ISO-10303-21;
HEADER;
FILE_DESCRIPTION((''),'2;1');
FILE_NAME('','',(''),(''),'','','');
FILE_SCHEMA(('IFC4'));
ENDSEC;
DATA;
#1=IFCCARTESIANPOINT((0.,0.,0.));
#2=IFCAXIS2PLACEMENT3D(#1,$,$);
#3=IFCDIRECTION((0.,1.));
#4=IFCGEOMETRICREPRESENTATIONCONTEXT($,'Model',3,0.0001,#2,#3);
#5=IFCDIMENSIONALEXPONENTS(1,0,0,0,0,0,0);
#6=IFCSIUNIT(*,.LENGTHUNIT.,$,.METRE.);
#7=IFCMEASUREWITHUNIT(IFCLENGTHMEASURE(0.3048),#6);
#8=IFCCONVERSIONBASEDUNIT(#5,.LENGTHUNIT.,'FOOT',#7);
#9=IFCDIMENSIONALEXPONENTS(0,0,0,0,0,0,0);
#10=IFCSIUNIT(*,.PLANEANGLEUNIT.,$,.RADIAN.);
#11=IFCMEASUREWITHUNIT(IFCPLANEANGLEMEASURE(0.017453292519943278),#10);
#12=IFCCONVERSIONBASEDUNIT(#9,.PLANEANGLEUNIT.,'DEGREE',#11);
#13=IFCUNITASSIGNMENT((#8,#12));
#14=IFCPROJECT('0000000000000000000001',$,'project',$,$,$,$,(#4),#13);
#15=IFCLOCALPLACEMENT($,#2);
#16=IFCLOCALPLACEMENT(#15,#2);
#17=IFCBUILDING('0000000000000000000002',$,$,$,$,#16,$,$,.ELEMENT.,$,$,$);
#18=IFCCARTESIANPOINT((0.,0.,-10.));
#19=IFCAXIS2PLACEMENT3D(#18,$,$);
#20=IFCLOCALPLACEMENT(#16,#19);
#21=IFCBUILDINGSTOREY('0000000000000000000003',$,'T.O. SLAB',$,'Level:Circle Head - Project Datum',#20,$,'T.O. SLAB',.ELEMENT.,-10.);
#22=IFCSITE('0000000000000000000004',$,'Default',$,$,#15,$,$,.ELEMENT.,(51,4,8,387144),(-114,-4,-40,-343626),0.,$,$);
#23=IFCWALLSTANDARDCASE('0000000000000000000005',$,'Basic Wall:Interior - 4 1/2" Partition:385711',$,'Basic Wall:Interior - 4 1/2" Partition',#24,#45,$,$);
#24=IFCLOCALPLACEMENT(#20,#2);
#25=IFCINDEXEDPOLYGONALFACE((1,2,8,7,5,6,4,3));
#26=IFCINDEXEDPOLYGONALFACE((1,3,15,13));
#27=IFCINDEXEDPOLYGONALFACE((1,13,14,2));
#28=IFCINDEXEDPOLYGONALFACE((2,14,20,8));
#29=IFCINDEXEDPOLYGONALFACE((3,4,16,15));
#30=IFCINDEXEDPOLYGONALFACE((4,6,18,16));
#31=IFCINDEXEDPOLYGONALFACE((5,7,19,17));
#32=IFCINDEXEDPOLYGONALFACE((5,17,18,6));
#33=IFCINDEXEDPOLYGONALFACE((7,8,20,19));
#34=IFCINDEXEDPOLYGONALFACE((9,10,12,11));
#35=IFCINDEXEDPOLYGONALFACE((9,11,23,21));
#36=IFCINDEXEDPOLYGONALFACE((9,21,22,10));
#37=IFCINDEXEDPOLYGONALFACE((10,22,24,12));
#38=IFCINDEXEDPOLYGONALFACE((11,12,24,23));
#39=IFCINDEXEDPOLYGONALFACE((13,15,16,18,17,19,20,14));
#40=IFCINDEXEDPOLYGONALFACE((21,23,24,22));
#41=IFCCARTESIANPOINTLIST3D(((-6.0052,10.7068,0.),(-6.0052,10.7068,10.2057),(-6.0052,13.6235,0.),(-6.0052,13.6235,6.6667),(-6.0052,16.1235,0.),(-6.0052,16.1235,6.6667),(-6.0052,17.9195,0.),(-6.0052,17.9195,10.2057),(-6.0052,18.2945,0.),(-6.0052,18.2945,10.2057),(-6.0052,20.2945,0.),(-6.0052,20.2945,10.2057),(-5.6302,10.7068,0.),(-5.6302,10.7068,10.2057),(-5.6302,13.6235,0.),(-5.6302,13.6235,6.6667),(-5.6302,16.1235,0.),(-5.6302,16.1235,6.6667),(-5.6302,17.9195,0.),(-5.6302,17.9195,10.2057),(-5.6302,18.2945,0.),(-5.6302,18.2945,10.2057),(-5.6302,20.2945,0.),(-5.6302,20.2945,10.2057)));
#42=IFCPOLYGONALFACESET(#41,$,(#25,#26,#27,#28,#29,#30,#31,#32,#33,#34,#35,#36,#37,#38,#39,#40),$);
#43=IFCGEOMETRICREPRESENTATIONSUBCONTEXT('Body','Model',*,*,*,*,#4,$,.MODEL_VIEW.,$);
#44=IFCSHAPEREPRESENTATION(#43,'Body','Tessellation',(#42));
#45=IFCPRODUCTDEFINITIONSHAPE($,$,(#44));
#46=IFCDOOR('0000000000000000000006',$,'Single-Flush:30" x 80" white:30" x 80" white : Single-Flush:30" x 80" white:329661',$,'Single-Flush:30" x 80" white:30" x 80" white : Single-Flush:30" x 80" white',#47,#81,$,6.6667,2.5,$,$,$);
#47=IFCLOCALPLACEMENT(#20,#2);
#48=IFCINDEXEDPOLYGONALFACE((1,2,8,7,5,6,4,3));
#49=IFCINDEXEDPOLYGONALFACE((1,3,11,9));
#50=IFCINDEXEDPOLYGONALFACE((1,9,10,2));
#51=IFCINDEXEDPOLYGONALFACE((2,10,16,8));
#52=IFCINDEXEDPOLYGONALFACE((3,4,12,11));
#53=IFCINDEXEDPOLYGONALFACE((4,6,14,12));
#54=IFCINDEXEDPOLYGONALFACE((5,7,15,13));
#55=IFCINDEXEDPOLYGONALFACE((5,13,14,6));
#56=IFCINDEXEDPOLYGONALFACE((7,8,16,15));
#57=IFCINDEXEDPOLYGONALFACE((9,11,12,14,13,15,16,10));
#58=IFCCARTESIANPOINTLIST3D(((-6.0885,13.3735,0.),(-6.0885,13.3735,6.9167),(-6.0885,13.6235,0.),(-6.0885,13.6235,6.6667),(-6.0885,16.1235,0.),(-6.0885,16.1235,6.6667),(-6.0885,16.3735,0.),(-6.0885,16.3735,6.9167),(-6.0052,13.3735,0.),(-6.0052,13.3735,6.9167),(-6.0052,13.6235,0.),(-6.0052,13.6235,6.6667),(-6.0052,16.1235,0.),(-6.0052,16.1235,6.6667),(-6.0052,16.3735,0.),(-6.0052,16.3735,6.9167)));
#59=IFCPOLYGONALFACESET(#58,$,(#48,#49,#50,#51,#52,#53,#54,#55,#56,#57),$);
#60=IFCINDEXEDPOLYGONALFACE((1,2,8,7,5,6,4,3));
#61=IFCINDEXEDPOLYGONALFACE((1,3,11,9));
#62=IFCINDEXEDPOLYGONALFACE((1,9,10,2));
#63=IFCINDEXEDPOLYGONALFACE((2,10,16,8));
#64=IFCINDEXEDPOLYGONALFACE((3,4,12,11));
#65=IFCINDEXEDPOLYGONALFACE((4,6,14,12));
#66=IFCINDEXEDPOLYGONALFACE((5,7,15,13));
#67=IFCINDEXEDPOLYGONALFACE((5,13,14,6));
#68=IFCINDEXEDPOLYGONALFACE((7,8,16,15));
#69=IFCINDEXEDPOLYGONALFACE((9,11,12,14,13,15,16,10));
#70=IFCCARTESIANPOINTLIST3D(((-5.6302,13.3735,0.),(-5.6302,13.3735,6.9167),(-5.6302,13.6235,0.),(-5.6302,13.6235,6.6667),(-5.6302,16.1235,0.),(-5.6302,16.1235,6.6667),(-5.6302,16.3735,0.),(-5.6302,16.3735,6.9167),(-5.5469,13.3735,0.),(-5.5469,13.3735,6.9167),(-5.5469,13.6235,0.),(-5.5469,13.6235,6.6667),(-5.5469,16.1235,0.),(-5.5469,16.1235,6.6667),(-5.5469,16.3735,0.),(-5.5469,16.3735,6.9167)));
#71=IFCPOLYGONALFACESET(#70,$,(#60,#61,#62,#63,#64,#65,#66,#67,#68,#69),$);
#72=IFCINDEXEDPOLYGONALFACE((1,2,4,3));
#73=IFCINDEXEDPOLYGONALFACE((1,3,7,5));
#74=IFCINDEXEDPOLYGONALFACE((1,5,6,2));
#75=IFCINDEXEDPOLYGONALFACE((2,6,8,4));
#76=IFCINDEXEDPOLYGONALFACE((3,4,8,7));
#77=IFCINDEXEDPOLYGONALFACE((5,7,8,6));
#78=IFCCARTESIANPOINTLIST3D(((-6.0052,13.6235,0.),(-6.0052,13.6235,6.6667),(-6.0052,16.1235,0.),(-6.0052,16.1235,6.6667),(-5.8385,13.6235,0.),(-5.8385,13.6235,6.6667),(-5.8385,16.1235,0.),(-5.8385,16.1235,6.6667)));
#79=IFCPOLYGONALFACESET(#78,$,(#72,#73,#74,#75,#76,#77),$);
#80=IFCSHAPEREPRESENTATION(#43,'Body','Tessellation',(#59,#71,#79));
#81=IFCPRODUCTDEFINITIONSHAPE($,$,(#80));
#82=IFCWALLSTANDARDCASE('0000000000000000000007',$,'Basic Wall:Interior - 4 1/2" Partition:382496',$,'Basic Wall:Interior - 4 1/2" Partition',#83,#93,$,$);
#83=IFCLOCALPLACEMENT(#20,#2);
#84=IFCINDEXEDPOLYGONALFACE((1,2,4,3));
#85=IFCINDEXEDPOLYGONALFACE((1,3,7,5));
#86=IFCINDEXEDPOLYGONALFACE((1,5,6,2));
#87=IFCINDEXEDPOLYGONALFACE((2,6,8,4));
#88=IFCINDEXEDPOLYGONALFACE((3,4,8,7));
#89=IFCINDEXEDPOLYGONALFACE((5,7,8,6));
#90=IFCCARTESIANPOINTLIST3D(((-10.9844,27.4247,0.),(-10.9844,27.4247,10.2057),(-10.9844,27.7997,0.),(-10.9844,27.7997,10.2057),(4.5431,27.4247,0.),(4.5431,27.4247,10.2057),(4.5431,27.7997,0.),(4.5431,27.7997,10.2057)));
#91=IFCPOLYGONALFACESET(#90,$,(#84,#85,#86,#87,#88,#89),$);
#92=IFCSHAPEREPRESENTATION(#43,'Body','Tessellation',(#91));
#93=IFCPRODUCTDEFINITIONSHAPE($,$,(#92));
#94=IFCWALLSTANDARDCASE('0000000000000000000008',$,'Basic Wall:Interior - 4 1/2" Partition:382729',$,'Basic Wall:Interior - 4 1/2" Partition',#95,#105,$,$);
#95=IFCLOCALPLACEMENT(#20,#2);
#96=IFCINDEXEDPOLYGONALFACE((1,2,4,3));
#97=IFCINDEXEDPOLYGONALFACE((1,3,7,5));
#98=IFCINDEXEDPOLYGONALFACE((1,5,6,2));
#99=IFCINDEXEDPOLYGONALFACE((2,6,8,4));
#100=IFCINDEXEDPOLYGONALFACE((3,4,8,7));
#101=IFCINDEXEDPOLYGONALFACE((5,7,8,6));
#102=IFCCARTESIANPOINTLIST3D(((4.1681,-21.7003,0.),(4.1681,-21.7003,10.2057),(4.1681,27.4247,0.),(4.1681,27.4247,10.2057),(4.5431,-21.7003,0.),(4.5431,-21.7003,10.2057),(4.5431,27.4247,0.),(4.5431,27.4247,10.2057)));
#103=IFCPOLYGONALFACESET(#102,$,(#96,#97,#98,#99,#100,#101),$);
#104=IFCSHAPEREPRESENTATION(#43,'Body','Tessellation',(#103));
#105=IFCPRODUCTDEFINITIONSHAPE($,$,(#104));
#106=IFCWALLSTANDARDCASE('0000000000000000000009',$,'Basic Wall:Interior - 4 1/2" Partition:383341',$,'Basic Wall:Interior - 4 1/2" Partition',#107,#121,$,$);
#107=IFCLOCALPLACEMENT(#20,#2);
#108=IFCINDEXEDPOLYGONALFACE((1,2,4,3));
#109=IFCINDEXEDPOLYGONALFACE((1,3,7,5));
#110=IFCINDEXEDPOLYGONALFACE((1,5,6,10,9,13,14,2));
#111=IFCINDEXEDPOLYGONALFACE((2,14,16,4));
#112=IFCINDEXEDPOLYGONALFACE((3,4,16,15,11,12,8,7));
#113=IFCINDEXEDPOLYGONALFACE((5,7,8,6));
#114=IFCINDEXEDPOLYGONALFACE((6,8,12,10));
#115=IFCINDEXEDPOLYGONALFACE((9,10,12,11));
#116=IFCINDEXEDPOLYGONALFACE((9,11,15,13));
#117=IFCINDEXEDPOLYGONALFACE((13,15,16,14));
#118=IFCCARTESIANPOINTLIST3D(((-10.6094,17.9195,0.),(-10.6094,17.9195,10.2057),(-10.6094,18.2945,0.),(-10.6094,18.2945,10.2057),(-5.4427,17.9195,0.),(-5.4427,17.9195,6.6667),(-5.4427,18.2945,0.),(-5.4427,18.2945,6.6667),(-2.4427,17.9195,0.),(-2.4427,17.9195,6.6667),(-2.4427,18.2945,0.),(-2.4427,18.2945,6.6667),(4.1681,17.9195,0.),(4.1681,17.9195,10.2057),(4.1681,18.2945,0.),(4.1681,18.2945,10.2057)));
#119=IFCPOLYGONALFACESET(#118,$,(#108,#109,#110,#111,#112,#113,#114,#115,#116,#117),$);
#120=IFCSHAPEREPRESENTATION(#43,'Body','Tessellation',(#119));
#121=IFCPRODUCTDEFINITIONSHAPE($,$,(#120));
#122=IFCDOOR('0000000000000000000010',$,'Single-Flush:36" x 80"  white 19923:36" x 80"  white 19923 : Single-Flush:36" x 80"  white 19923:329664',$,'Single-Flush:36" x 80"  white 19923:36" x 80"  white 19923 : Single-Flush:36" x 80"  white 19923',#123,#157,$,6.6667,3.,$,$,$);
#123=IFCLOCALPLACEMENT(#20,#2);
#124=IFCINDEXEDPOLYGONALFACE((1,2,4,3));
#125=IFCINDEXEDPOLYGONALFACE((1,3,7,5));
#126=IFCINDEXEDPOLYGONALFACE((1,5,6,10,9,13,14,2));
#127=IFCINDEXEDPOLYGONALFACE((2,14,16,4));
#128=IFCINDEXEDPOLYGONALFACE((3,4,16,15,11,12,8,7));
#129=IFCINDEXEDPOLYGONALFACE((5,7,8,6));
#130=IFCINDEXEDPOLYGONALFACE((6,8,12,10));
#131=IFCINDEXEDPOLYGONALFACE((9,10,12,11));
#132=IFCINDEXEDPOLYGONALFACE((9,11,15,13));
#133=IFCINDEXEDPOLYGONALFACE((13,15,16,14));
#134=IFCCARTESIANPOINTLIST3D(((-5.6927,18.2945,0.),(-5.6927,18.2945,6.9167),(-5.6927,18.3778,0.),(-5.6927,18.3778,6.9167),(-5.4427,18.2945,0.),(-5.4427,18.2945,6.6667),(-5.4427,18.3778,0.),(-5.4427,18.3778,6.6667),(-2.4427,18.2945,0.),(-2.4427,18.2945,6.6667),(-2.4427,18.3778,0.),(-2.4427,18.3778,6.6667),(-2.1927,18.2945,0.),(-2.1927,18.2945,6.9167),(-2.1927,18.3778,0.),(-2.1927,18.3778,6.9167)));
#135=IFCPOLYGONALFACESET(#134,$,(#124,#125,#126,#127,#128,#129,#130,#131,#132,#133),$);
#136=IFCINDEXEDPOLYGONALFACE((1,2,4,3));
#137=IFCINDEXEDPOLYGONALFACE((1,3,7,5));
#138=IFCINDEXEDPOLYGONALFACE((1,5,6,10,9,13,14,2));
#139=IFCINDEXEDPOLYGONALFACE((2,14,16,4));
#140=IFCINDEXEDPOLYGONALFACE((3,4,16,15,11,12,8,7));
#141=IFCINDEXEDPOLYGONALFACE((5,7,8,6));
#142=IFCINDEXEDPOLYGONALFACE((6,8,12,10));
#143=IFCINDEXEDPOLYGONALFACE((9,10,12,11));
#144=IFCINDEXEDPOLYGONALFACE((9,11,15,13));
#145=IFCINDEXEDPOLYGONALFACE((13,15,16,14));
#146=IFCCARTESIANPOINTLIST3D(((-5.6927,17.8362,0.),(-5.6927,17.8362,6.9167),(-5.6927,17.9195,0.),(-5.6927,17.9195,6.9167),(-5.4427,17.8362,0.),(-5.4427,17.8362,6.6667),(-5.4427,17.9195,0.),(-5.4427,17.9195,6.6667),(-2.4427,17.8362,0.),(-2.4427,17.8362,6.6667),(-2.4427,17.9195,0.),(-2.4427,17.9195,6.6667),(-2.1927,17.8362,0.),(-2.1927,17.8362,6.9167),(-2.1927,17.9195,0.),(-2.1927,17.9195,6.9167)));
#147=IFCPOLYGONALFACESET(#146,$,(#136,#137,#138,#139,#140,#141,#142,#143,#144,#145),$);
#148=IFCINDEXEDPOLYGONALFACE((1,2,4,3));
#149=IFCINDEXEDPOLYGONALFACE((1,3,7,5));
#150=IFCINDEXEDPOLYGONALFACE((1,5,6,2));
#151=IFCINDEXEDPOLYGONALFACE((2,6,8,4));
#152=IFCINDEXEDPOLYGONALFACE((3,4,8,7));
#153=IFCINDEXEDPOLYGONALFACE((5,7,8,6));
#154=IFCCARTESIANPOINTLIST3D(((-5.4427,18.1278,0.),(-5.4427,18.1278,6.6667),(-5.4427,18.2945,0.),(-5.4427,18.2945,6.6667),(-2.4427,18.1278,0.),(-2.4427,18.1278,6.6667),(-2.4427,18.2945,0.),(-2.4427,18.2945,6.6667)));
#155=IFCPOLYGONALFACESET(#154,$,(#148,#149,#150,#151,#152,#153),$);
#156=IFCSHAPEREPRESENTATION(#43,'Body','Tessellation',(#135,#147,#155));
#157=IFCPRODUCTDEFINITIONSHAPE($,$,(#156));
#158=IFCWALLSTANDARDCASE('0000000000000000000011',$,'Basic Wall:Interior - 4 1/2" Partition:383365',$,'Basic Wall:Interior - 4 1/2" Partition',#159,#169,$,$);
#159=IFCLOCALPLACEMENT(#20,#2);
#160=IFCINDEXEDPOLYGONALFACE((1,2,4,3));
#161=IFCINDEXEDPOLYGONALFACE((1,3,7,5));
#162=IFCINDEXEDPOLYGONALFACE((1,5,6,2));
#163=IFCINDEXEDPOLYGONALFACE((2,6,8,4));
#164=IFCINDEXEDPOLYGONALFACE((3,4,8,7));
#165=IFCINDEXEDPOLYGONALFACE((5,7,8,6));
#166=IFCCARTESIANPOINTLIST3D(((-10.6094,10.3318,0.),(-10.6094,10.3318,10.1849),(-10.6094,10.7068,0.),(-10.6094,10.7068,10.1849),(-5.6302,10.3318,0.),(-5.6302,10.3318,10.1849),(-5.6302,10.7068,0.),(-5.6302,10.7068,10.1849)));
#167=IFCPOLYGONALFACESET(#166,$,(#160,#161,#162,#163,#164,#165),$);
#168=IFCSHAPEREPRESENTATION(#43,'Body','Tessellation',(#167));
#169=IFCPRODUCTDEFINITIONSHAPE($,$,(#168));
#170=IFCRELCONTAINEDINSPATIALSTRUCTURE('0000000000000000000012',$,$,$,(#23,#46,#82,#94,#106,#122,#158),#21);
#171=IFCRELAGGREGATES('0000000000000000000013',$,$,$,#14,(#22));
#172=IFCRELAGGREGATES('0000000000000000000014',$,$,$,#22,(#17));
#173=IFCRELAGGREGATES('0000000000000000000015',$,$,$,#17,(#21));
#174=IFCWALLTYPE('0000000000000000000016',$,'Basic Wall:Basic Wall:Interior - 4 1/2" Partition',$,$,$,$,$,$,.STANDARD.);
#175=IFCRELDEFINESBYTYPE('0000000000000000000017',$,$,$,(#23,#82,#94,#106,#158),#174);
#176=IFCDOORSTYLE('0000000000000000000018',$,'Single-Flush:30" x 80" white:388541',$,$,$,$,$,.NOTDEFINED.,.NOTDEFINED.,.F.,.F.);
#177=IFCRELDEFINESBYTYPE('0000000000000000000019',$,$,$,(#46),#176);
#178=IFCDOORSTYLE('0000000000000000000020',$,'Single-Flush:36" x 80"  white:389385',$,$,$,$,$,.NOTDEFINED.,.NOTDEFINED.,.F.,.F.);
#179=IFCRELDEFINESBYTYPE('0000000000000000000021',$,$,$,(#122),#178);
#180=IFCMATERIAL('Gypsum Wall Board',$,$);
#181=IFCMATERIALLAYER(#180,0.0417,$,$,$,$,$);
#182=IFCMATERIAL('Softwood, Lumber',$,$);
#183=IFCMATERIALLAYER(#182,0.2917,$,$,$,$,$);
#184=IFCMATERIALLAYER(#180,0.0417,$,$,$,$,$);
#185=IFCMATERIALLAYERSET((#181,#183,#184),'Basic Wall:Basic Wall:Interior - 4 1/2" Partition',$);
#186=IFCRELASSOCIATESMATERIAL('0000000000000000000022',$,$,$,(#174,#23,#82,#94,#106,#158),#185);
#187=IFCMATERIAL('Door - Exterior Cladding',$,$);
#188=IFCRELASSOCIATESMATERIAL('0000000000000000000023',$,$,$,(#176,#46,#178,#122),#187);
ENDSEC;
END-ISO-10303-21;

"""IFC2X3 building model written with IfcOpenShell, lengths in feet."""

from ifc_helpers import new_model, entity, si_unit, converted_unit, direction, frame, frame_2d, origin, place, context, subcontext, project, spatial, polyline, rectangle, outline, extrude, source, transform, mapped, material, layer, layer_set, layer_usage, type_object, type_shapes, element, fill, save


model = new_model("IFC2X3")

# Units and contexts
model_context = context("Model", 3, precision=0.0001, world=origin(), true_north=direction((0.0, 1.0)))
body_context = subcontext(model_context, "Body", "Model", "MODEL_VIEW")
ifc_project = project(units=[converted_unit("LENGTHUNIT", "FOOT", entity("IfcLengthMeasure", 0.3048), si_unit("LENGTHUNIT", "METRE"), dimensions=[1, 0, 0, 0, 0, 0, 0]), converted_unit("PLANEANGLEUNIT", "DEGREE", entity("IfcPlaneAngleMeasure", 0.017453292519943278), si_unit("PLANEANGLEUNIT", "RADIAN"), dimensions=[0, 0, 0, 0, 0, 0, 0])], contexts=[model_context])

# Site, building, storey
site_placement = place(None, origin())
site = spatial("IfcSite", under=ifc_project, at=site_placement, Name="Default", CompositionType="ELEMENT", RefLatitude=(51, 4, 8, 387144), RefLongitude=(-114, -4, -40, -343626), RefElevation=0.0)
building_placement = place(site_placement, origin())
building = spatial("IfcBuilding", under=site, at=building_placement, CompositionType="ELEMENT")
storey_placement = place(building_placement, frame((0.0, 0.0, -10.0)))
storey = spatial("IfcBuildingStorey", under=building, at=storey_placement, Name="T.O. SLAB", ObjectType="Level:Circle Head - Project Datum", LongName="T.O. SLAB", CompositionType="ELEMENT", Elevation=-10.0)

# Wall, openings, door
ifc_material_1 = material(Name="Gypsum Wall Board")
ifc_layer_1 = layer(ifc_material_1, 0.0417)
ifc_material_2 = material(Name="Softwood, Lumber")
ifc_layer_2 = layer(ifc_material_2, 0.2917)
ifc_layer_3 = layer(ifc_material_1, 0.0417)
ifc_layer_set_1 = layer_set([ifc_layer_1, ifc_layer_2, ifc_layer_3], Name="Basic Wall:Basic Wall:Interior - 4 1/2\" Partition")
ifc_layer_usage_1 = layer_usage(ifc_layer_set_1, "AXIS2", "NEGATIVE", 0.1875)
wall_type_1 = type_object("IfcWallType", Name="Basic Wall:Basic Wall:Interior - 4 1/2\" Partition", PredefinedType="STANDARD", material=ifc_layer_set_1)
wall_1_placement = place(storey_placement, frame((-5.8177, 20.2945, 0.0), z_axis=(0.0, 0.0, 1.0), x_axis=(0.0, -1.0, 0.0)))
wall_1 = element("IfcWallStandardCase", 1, at=wall_1_placement, inside=storey, type_object=wall_type_1, material=ifc_layer_usage_1, Name="Basic Wall:Interior - 4 1/2\" Partition:385711", ObjectType="Basic Wall:Interior - 4 1/2\" Partition", context=body_context, shape_type="SweptSolid", body=[
    extrude(rectangle(XDim=9.5877, YDim=0.375, at=frame_2d((4.7938, 0.0), x_axis=(-1.0, 0.0))), origin(), (0.0, 0.0, 1.0), 10.2057),
])
opening_1_placement = place(wall_1_placement, origin())
element("IfcOpeningElement", 2, at=opening_1_placement, cuts=wall_1, ObjectType="Opening", context=body_context, shape_type="SweptSolid", body=[
    extrude(rectangle(XDim=10.2057, YDim=0.375, at=frame_2d((0.0, 0.0), x_axis=(0.0, 1.0))), frame((2.1875, -0.1875, 5.1029), z_axis=(0.0, 1.0, 0.0), x_axis=(1.0, 0.0, 0.0)), (0.0, 0.0, 1.0), 0.375),
])
opening_2_placement = place(wall_1_placement, frame((20.2945, 5.8177, 0.0), z_axis=(0.0, 0.0, 1.0), x_axis=(0.0, 1.0, 0.0)))
opening_2 = element("IfcOpeningElement", 3, at=opening_2_placement, cuts=wall_1, ObjectType="Opening", context=body_context, shape_type="SweptSolid", body=[
    extrude(rectangle(XDim=6.6667, YDim=2.5, at=frame_2d((0.0, 0.0), x_axis=(0.0, 1.0))), frame((-6.009, 14.8735, 3.3333), z_axis=(1.0, 0.0, 0.0), x_axis=(0.0, -1.0, 0.0)), (0.0, 0.0, 1.0), 0.3825),
])
ifc_material_3 = material(Name="Door - Exterior Cladding")
door_style_1 = type_object("IfcDoorStyle", Name="Single-Flush:30\" x 80\" white:388541", ConstructionType="NOTDEFINED", OperationType="NOTDEFINED", ParameterTakesPrecedence=False, Sizeable=False, material=ifc_material_3)
shared_shape_1 = source(origin(), body_context, "Body", "SweptSolid", [
    extrude(outline(polyline([(-3.5208, -1.5), (3.3958, -1.5), (3.3958, -1.25), (-3.2708, -1.25), (-3.2708, 1.25), (3.3958, 1.25), (3.3958, 1.5), (-3.5208, 1.5), (-3.5208, -1.5)])), frame((1.25, 0.3788, 3.3958), z_axis=(0.0, 1.0, 0.0), x_axis=(0.0, 0.0, -1.0)), (0.0, 0.0, 1.0), 0.0833),
    extrude(outline(polyline([(-1.5, -3.3958), (-1.25, -3.3958), (-1.25, 3.2708), (1.25, 3.2708), (1.25, -3.3958), (1.5, -3.3958), (1.5, 3.5208), (-1.5, 3.5208), (-1.5, -3.3958)])), frame((1.25, -0.0796, 3.3958), z_axis=(0.0, 1.0, 0.0), x_axis=(-1.0, 0.0, 0.0)), (0.0, 0.0, 1.0), 0.0833),
    extrude(rectangle(XDim=2.5, YDim=0.1667, at=frame_2d((0.0, 0.0), x_axis=(1.0, 0.0))), frame((1.25, 0.2954, 0.0), z_axis=(0.0, 0.0, 1.0), x_axis=(-1.0, 0.0, 0.0)), (0.0, 0.0, 1.0), 6.6667),
])
type_shapes(door_style_1, [shared_shape_1])
door_1_placement = place(opening_2_placement, frame((-5.6265, 13.6235, 0.0), z_axis=(0.0, 0.0, 1.0), x_axis=(0.0, 1.0, 0.0)))
door_1 = element("IfcDoor", 4, at=door_1_placement, inside=storey, type_object=door_style_1, material=ifc_material_3, Name="Single-Flush:30\" x 80\" white:30\" x 80\" white : Single-Flush:30\" x 80\" white:329661", ObjectType="Single-Flush:30\" x 80\" white:30\" x 80\" white : Single-Flush:30\" x 80\" white", OverallHeight=6.6667, OverallWidth=2.5, context=body_context, shape_type="MappedRepresentation", body=[
    mapped(shared_shape_1, transform((0.0, 0.0, 0.0), scale=1.0)),
])
fill(opening_2, door_1)

# Walls
ifc_layer_usage_2 = layer_usage(ifc_layer_set_1, "AXIS2", "NEGATIVE", 0.1875)
wall_2_placement = place(storey_placement, frame((-10.9844, 27.6122, 0.0)))
element("IfcWallStandardCase", 5, at=wall_2_placement, inside=storey, type_object=wall_type_1, material=ifc_layer_usage_2, Name="Basic Wall:Interior - 4 1/2\" Partition:382496", ObjectType="Basic Wall:Interior - 4 1/2\" Partition", context=body_context, shape_type="SweptSolid", body=[
    extrude(rectangle(XDim=15.5275, YDim=0.375, at=frame_2d((7.7637, 0.0), x_axis=(-1.0, 0.0))), origin(), (0.0, 0.0, 1.0), 10.2057),
])
ifc_layer_usage_3 = layer_usage(ifc_layer_set_1, "AXIS2", "NEGATIVE", 0.1875)
wall_3_placement = place(storey_placement, frame((4.3556, 27.4247, 0.0), z_axis=(0.0, 0.0, 1.0), x_axis=(0.0, -1.0, 0.0)))
element("IfcWallStandardCase", 6, at=wall_3_placement, inside=storey, type_object=wall_type_1, material=ifc_layer_usage_3, Name="Basic Wall:Interior - 4 1/2\" Partition:382729", ObjectType="Basic Wall:Interior - 4 1/2\" Partition", context=body_context, shape_type="SweptSolid", body=[
    extrude(rectangle(XDim=49.125, YDim=0.375, at=frame_2d((24.5625, 0.0), x_axis=(-1.0, 0.0))), origin(), (0.0, 0.0, 1.0), 10.2057),
])

# Wall, opening, door
ifc_layer_usage_4 = layer_usage(ifc_layer_set_1, "AXIS2", "NEGATIVE", 0.1875)
wall_4_placement = place(storey_placement, frame((-10.6094, 18.107, 0.0)))
wall_4 = element("IfcWallStandardCase", 7, at=wall_4_placement, inside=storey, type_object=wall_type_1, material=ifc_layer_usage_4, Name="Basic Wall:Interior - 4 1/2\" Partition:383341", ObjectType="Basic Wall:Interior - 4 1/2\" Partition", context=body_context, shape_type="SweptSolid", body=[
    extrude(rectangle(XDim=0.375, YDim=14.7775, at=frame_2d((7.3887, 0.0), x_axis=(0.0, 1.0))), origin(), (0.0, 0.0, 1.0), 10.2057),
])
opening_3_placement = place(wall_4_placement, frame((10.6094, -18.107, 0.0)))
opening_3 = element("IfcOpeningElement", 8, at=opening_3_placement, cuts=wall_4, ObjectType="Opening", context=body_context, shape_type="SweptSolid", body=[
    extrude(rectangle(XDim=6.6667, YDim=3.0, at=frame_2d((0.0, 0.0), x_axis=(1.0, 0.0))), frame((-3.9427, 17.9158, 3.3333), z_axis=(0.0, 1.0, 0.0), x_axis=(0.0, 0.0, 1.0)), (0.0, 0.0, 1.0), 0.3825),
])
door_style_2 = type_object("IfcDoorStyle", Name="Single-Flush:36\" x 80\"  white:389385", ConstructionType="NOTDEFINED", OperationType="NOTDEFINED", ParameterTakesPrecedence=False, Sizeable=False, material=ifc_material_3)
shared_shape_2 = source(origin(), body_context, "Body", "SweptSolid", [
    extrude(outline(polyline([(-1.75, -3.5208), (1.75, -3.5208), (1.75, 3.3958), (1.5, 3.3958), (1.5, -3.2708), (-1.5, -3.2708), (-1.5, 3.3958), (-1.75, 3.3958), (-1.75, -3.5208)])), frame((1.5, -0.0038, 3.3958), z_axis=(0.0, 1.0, 0.0), x_axis=(1.0, 0.0, 0.0)), (0.0, 0.0, 1.0), 0.0833),
    extrude(outline(polyline([(-3.3958, -1.75), (3.5208, -1.75), (3.5208, 1.75), (-3.3958, 1.75), (-3.3958, 1.5), (3.2708, 1.5), (3.2708, -1.5), (-3.3958, -1.5), (-3.3958, -1.75)])), frame((1.5, -0.4621, 3.3958), z_axis=(0.0, 1.0, 0.0), x_axis=(0.0, 0.0, 1.0)), (0.0, 0.0, 1.0), 0.0833),
    extrude(rectangle(XDim=0.1667, YDim=3.0, at=frame_2d((0.0, 0.0), x_axis=(1.0, 0.0))), frame((1.5, -0.0871, 0.0), z_axis=(0.0, 0.0, 1.0), x_axis=(0.0, 1.0, 0.0)), (0.0, 0.0, 1.0), 6.6667),
])
type_shapes(door_style_2, [shared_shape_2])
door_2_placement = place(opening_3_placement, frame((-5.4427, 18.2983, 0.0)))
door_2 = element("IfcDoor", 9, at=door_2_placement, inside=storey, type_object=door_style_2, material=ifc_material_3, Name="Single-Flush:36\" x 80\"  white 19923:36\" x 80\"  white 19923 : Single-Flush:36\" x 80\"  white 19923:329664", ObjectType="Single-Flush:36\" x 80\"  white 19923:36\" x 80\"  white 19923 : Single-Flush:36\" x 80\"  white 19923", OverallHeight=6.6667, OverallWidth=3.0, context=body_context, shape_type="MappedRepresentation", body=[
    mapped(shared_shape_2, transform((0.0, 0.0, 0.0), scale=1.0)),
])
fill(opening_3, door_2)

# Wall
ifc_layer_usage_5 = layer_usage(ifc_layer_set_1, "AXIS2", "NEGATIVE", 0.1875)
wall_5_placement = place(storey_placement, frame((-5.6302, 10.5193, 0.0), z_axis=(0.0, 0.0, 1.0), x_axis=(-1.0, 0.0, 0.0)))
element("IfcWallStandardCase", 10, at=wall_5_placement, inside=storey, type_object=wall_type_1, material=ifc_layer_usage_5, Name="Basic Wall:Interior - 4 1/2\" Partition:383365", ObjectType="Basic Wall:Interior - 4 1/2\" Partition", context=body_context, shape_type="SweptSolid", body=[
    extrude(rectangle(XDim=4.9792, YDim=0.375, at=frame_2d((2.4896, 0.0), x_axis=(-1.0, 0.0))), origin(), (0.0, 0.0, 1.0), 10.1849),
])

save(model, "model.ifc")
